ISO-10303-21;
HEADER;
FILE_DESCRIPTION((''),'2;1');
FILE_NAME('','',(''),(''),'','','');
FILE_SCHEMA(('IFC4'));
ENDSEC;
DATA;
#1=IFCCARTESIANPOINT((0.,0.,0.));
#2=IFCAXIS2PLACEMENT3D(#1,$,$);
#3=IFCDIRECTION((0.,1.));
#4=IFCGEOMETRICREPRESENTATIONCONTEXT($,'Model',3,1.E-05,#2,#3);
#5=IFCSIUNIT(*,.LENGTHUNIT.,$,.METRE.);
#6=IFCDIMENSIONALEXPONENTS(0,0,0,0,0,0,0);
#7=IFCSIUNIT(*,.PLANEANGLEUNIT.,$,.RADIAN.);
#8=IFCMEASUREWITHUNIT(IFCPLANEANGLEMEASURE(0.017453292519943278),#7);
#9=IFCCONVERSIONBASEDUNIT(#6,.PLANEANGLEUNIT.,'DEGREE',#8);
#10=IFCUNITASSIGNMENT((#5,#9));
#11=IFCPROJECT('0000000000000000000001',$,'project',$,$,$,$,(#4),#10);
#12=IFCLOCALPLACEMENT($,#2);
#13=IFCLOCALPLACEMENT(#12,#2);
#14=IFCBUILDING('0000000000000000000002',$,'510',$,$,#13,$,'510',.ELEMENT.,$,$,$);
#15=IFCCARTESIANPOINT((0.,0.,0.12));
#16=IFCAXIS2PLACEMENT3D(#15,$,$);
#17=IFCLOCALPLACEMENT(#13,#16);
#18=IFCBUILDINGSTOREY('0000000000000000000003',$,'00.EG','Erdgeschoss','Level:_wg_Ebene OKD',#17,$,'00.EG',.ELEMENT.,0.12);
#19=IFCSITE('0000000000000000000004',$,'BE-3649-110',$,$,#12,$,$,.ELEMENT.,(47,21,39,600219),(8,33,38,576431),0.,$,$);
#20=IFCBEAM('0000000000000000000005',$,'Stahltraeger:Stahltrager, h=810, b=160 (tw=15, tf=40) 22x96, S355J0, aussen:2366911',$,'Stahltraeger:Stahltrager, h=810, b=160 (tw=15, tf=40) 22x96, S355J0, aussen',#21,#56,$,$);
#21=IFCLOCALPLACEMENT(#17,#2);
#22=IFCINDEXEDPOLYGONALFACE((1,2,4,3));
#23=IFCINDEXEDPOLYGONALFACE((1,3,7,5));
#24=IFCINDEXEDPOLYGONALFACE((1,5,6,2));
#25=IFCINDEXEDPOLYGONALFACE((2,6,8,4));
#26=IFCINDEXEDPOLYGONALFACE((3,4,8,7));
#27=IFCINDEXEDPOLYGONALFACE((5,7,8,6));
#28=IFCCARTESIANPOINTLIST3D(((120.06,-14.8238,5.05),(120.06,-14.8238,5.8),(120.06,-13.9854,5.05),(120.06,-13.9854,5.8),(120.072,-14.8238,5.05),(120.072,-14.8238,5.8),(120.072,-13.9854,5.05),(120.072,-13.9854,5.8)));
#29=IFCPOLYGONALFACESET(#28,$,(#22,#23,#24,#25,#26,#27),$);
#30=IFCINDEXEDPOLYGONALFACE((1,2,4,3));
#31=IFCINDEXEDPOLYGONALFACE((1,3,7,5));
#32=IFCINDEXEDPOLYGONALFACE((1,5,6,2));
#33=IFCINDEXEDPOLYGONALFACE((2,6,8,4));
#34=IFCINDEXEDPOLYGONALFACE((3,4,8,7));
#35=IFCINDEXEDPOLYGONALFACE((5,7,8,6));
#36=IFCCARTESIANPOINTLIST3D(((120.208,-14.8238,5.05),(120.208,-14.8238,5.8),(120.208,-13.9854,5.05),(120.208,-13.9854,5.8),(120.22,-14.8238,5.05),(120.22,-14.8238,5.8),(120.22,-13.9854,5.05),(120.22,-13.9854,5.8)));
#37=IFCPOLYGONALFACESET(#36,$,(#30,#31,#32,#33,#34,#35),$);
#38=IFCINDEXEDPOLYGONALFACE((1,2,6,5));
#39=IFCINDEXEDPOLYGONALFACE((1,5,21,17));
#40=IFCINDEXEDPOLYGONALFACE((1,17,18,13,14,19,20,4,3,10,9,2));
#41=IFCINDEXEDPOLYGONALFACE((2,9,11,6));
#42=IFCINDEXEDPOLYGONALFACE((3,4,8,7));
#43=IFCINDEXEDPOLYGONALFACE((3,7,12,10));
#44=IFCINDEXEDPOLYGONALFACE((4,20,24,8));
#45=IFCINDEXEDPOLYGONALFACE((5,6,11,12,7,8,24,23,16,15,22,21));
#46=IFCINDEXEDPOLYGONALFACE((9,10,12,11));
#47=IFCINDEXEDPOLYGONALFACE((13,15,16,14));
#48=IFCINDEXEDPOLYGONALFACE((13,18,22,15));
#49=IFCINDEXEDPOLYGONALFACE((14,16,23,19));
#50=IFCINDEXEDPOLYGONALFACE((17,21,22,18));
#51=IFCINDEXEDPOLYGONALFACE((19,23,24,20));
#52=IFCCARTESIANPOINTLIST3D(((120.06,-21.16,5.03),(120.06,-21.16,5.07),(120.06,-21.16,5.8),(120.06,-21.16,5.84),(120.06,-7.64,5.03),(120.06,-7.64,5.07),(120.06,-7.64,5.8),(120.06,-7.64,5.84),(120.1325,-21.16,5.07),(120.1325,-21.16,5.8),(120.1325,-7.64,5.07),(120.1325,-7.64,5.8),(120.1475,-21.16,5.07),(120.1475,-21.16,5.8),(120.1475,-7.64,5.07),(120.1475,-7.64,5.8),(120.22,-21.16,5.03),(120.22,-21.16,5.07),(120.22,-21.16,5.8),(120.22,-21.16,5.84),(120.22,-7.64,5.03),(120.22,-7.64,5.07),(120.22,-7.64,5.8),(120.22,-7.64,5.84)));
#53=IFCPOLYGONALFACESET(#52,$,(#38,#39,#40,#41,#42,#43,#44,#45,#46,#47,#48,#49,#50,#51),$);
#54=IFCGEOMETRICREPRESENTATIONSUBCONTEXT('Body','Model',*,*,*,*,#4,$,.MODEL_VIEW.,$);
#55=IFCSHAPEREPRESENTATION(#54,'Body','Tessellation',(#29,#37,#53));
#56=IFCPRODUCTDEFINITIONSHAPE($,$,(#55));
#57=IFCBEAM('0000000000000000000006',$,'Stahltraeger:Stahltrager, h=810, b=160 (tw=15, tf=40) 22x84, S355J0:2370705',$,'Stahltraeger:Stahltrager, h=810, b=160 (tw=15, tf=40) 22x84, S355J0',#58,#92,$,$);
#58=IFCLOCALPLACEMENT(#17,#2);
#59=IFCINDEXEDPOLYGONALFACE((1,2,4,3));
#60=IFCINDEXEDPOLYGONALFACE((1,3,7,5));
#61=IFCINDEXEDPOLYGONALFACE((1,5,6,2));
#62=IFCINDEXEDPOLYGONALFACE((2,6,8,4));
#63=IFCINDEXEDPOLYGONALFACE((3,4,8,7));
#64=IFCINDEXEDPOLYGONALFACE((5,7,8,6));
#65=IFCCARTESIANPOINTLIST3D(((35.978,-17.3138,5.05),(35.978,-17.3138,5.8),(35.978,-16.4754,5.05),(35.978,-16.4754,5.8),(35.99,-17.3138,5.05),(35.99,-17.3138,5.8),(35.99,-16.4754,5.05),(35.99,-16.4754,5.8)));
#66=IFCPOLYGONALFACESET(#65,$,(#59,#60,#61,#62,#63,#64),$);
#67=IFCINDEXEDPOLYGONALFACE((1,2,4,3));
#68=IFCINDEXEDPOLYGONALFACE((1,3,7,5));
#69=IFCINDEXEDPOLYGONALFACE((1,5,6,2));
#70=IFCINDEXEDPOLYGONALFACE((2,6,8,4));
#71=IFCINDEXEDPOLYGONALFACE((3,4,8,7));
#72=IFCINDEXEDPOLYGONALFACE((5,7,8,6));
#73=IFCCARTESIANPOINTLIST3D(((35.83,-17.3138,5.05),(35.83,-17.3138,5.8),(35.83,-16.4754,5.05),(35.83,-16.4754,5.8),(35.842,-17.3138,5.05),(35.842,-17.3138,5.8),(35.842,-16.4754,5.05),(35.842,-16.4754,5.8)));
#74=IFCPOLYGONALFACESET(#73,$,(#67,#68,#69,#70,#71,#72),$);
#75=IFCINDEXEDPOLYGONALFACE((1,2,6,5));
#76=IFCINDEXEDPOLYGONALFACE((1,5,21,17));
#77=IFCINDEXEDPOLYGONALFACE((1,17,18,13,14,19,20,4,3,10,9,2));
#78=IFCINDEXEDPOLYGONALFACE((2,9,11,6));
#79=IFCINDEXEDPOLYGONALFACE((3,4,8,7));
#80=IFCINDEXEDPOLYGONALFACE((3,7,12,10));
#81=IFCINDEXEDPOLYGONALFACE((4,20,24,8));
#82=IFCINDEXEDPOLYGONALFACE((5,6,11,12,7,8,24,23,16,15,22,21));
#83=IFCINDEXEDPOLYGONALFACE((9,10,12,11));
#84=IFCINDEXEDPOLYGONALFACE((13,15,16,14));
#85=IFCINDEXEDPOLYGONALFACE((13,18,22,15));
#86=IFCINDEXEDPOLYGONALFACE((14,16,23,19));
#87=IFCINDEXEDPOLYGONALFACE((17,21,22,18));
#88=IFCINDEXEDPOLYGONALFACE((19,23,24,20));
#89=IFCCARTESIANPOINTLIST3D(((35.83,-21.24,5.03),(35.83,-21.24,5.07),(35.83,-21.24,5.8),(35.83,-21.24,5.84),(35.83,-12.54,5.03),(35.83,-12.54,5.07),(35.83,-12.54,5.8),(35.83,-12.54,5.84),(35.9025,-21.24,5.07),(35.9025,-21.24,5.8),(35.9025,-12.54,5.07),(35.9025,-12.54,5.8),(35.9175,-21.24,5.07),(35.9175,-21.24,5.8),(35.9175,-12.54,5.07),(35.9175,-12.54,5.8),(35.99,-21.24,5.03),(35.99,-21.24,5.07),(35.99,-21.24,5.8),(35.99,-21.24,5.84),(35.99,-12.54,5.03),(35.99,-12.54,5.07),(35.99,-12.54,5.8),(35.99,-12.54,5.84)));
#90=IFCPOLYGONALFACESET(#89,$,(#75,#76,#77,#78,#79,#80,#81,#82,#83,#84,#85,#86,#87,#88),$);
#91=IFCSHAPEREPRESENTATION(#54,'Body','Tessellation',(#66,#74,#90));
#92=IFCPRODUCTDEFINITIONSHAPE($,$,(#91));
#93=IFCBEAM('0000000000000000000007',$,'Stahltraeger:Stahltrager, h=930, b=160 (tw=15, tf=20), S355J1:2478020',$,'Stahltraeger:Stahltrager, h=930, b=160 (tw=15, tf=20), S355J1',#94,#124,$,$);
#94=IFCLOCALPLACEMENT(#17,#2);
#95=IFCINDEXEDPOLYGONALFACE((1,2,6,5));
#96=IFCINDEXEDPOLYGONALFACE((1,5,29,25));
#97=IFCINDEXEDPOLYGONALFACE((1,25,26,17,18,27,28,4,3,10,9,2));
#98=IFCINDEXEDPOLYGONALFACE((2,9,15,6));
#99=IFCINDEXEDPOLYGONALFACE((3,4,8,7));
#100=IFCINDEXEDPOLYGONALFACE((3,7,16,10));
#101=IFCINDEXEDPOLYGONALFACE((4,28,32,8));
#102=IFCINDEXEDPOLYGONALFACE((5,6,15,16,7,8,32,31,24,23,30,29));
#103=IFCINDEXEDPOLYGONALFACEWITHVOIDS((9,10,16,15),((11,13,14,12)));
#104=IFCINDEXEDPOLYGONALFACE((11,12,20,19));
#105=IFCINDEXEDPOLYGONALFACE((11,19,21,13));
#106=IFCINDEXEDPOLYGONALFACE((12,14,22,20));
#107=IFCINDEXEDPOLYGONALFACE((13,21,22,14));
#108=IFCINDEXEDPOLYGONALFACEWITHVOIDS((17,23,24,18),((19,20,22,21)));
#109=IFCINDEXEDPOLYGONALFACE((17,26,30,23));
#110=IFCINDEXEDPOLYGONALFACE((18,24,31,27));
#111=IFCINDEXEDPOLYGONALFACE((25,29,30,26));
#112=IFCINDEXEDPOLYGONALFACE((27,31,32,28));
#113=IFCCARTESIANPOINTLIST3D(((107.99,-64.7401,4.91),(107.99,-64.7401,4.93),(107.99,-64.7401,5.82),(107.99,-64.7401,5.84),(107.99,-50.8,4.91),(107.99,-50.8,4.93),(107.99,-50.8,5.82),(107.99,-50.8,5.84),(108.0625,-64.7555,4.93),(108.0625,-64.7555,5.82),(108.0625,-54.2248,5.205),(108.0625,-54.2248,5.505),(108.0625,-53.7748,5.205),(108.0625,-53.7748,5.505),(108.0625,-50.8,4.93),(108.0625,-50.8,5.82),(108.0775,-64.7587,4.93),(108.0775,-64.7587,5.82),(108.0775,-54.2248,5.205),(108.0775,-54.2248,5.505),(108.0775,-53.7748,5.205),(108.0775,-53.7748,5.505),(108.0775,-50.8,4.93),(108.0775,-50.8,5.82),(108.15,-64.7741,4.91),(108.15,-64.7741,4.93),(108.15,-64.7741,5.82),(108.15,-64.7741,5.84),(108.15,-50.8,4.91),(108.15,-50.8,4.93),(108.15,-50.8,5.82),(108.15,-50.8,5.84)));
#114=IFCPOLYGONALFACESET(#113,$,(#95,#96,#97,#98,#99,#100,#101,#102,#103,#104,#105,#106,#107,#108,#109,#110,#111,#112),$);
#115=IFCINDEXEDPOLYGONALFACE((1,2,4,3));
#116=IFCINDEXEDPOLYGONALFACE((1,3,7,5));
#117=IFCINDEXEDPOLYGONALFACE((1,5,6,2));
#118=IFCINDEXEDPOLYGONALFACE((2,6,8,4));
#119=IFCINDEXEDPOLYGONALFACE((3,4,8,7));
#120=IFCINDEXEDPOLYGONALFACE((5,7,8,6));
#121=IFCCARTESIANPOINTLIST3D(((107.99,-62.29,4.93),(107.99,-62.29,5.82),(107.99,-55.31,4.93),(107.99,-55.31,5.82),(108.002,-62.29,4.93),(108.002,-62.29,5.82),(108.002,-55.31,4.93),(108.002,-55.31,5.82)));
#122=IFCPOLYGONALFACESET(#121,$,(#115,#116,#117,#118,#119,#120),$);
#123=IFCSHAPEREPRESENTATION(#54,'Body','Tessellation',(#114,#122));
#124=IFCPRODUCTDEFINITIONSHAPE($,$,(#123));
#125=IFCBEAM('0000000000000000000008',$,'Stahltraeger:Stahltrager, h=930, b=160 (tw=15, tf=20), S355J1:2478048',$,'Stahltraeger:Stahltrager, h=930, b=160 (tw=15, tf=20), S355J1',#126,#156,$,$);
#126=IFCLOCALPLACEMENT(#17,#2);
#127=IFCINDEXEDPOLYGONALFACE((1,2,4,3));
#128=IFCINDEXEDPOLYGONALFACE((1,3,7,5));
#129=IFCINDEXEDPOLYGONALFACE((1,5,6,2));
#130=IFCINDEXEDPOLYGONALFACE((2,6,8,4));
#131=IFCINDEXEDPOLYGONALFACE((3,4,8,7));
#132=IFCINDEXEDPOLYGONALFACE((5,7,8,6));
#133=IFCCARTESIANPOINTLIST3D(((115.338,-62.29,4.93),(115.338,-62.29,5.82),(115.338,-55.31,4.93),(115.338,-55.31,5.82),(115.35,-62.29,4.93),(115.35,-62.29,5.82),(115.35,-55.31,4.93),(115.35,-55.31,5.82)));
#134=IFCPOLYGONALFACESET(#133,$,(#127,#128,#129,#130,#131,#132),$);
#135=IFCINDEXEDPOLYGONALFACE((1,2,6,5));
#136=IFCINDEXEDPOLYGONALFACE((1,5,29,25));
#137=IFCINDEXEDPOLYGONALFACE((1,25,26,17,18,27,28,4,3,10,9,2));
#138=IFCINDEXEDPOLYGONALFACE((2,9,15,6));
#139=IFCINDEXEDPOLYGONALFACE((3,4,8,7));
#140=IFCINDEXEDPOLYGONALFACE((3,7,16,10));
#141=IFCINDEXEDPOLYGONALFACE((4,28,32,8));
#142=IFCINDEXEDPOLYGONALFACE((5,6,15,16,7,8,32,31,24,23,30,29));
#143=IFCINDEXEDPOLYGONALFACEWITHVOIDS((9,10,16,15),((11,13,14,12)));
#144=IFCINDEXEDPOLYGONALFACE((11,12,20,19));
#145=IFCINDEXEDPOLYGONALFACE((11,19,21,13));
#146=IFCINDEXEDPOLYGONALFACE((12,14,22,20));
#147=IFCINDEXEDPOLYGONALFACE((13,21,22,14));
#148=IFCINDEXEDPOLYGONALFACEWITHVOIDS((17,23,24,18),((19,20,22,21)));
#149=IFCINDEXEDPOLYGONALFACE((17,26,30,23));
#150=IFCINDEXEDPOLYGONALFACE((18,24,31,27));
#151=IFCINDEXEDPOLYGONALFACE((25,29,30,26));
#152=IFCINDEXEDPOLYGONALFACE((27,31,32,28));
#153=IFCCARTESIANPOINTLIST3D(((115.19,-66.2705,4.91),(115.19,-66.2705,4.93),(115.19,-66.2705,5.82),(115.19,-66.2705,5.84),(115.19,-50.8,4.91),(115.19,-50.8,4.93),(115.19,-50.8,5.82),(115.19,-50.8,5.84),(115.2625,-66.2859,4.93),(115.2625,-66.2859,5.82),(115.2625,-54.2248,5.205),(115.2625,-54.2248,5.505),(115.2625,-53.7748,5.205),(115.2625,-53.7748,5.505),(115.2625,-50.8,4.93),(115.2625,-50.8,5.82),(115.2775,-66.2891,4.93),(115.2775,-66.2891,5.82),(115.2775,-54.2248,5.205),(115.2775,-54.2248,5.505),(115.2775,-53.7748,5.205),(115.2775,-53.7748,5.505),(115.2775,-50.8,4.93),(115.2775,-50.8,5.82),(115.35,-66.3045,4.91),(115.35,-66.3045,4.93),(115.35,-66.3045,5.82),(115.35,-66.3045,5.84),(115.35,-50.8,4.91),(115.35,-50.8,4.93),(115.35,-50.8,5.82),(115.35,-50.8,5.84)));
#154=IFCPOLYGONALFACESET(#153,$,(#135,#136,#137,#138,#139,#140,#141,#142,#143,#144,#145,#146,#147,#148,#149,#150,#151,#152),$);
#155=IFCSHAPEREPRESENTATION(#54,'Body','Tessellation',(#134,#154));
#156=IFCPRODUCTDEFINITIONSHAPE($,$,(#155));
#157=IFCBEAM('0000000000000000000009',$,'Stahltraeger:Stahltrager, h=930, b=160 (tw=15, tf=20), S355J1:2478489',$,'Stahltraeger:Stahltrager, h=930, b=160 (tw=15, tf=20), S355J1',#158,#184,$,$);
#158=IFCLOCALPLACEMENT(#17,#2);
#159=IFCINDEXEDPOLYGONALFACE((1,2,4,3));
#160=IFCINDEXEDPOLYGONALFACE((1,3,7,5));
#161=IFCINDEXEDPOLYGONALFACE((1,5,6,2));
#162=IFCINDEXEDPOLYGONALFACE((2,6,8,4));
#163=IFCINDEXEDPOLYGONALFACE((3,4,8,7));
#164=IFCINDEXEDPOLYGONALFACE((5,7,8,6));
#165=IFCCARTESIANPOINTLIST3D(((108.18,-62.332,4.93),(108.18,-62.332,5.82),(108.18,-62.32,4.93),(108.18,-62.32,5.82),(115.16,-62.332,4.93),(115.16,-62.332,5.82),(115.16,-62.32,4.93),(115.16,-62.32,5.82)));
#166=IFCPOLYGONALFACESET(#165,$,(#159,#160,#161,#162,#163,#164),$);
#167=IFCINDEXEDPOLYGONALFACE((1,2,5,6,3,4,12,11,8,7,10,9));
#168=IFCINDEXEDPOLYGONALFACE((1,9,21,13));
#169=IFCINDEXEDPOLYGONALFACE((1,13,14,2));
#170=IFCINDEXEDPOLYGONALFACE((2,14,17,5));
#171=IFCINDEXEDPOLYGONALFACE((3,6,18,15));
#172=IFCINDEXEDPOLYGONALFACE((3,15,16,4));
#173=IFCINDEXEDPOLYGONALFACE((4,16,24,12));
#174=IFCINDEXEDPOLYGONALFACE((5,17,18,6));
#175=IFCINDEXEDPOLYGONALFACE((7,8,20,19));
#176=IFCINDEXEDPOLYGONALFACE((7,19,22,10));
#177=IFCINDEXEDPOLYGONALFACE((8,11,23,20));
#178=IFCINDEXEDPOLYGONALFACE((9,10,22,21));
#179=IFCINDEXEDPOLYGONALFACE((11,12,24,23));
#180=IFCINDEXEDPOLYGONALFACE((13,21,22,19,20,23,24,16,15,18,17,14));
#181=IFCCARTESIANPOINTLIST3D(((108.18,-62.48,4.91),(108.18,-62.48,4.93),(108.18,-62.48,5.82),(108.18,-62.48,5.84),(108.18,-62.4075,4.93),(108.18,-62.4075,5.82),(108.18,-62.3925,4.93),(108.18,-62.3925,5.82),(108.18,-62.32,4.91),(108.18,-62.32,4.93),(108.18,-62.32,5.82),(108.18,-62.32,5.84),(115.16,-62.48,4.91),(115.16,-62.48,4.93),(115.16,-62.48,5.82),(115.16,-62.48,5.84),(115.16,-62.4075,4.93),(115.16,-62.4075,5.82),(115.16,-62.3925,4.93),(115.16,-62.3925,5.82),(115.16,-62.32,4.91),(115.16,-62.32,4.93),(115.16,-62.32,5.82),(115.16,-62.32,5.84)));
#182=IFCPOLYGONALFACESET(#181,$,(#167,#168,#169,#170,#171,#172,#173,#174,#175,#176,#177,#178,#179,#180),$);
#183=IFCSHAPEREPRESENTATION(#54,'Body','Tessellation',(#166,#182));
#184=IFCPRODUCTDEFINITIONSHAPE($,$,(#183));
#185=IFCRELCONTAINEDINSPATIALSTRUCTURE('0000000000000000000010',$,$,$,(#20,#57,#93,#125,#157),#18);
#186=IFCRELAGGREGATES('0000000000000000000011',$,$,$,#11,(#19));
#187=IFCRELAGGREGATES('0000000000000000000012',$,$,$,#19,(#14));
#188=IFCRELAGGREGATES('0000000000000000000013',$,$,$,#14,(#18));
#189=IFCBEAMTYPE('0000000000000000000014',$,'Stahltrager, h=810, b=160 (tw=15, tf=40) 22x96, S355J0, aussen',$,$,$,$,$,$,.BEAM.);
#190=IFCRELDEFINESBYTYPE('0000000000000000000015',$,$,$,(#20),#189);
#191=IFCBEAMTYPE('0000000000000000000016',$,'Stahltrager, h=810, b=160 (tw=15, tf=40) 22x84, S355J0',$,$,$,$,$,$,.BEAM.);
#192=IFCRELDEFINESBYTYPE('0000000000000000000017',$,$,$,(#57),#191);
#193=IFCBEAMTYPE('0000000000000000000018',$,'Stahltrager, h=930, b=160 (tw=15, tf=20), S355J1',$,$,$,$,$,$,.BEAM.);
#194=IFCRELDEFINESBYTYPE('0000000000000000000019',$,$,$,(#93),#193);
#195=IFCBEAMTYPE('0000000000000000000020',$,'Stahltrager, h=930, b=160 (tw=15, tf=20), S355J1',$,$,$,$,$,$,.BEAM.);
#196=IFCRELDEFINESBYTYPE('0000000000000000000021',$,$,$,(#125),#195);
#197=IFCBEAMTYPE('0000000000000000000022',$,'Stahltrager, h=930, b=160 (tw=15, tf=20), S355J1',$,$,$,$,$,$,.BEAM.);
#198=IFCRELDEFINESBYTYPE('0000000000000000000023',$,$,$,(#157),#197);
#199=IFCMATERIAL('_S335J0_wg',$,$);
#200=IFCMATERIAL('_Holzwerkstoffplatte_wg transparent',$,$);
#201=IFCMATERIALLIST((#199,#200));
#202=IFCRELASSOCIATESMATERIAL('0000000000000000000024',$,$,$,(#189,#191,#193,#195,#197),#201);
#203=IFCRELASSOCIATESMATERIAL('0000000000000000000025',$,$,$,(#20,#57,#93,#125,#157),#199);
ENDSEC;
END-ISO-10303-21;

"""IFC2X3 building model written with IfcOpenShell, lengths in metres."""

from ifc_helpers import new_model, entity, si_unit, converted_unit, direction, frame, frame_2d, origin, place, context, subcontext, project, spatial, rectangle, i_section, extrude, boolean, clip, halfspace, source, transform, mapped, material, material_list, type_object, type_shapes, element, save


model = new_model("IFC2X3")

# Units and contexts
model_context = context("Model", 3, precision=1e-05, world=origin(), true_north=direction((0.0, 1.0)))
body_context = subcontext(model_context, "Body", "Model", "MODEL_VIEW")
ifc_project = project(units=[si_unit("LENGTHUNIT", "METRE"), converted_unit("PLANEANGLEUNIT", "DEGREE", entity("IfcPlaneAngleMeasure", 0.017453292519943278), si_unit("PLANEANGLEUNIT", "RADIAN"), dimensions=[0, 0, 0, 0, 0, 0, 0])], contexts=[model_context])

# Site, building, storey
site_placement = place(None, origin())
site = spatial("IfcSite", under=ifc_project, at=site_placement, Name="BE-3649-110", CompositionType="ELEMENT", RefLatitude=(47, 21, 39, 600219), RefLongitude=(8, 33, 38, 576431), RefElevation=0.0)
building_placement = place(site_placement, origin())
building = spatial("IfcBuilding", under=site, at=building_placement, Name="510", LongName="510", CompositionType="ELEMENT")
storey_placement = place(building_placement, frame((0.0, 0.0, 0.12)))
storey = spatial("IfcBuildingStorey", under=building, at=storey_placement, Name="00.EG", Description="Erdgeschoss", ObjectType="Level:_wg_Ebene OKD", LongName="00.EG", CompositionType="ELEMENT", Elevation=0.12)

# Beams
ifc_material_1 = material(Name="_S335J0_wg")
ifc_material_2 = material(Name="_Holzwerkstoffplatte_wg transparent")
ifc_material_list = material_list([ifc_material_1, ifc_material_2])
beam_type_1 = type_object("IfcBeamType", Name="Stahltrager, h=810, b=160 (tw=15, tf=40) 22x96, S355J0, aussen", PredefinedType="BEAM", material=ifc_material_list)
shared_shape_1 = source(origin(), body_context, "Body", "SweptSolid", [
    extrude(rectangle(XDim=0.75, YDim=0.012, at=frame_2d((0.0, 0.0), x_axis=(0.0, 1.0))), frame((120.066, -13.9854, 5.545), z_axis=(0.0, -1.0, 0.0), x_axis=(-1.0, 0.0, 0.0)), (0.0, 0.0, 1.0), 0.8385),
    extrude(rectangle(XDim=0.75, YDim=0.012, at=frame_2d((0.0, 0.0), x_axis=(0.0, 1.0))), frame((120.214, -13.9854, 5.545), z_axis=(0.0, -1.0, 0.0), x_axis=(-1.0, 0.0, 0.0)), (0.0, 0.0, 1.0), 0.8385),
    extrude(i_section(OverallWidth=0.16, OverallDepth=0.81, WebThickness=0.015, FlangeThickness=0.04, at=frame_2d((0.0, 0.0), x_axis=(1.0, 0.0))), frame((120.14, -7.64, 5.555), z_axis=(0.0, -1.0, 0.0), x_axis=(-1.0, 0.0, 0.0)), (0.0, 0.0, 1.0), 13.52),
])
type_shapes(beam_type_1, [shared_shape_1])
beam_1_placement = place(storey_placement, frame((0.0, 0.0, -0.12)))
element("IfcBeam", 1, at=beam_1_placement, inside=storey, type_object=beam_type_1, material=ifc_material_1, Name="Stahltraeger:Stahltrager, h=810, b=160 (tw=15, tf=40) 22x96, S355J0, aussen:2366911", ObjectType="Stahltraeger:Stahltrager, h=810, b=160 (tw=15, tf=40) 22x96, S355J0, aussen", context=body_context, shape_type="MappedRepresentation", body=[
    mapped(shared_shape_1, transform((0.0, 0.0, 0.0), scale=1.0)),
])
beam_type_2 = type_object("IfcBeamType", Name="Stahltrager, h=810, b=160 (tw=15, tf=40) 22x84, S355J0", PredefinedType="BEAM", material=ifc_material_list)
shared_shape_2 = source(origin(), body_context, "Body", "SweptSolid", [
    extrude(rectangle(XDim=0.75, YDim=0.012, at=frame_2d((0.0, 0.0), x_axis=(0.0, 1.0))), frame((35.984, -16.4754, 5.545), z_axis=(0.0, -1.0, 0.0), x_axis=(-1.0, 0.0, 0.0)), (0.0, 0.0, 1.0), 0.8385),
    extrude(rectangle(XDim=0.75, YDim=0.012, at=frame_2d((0.0, 0.0), x_axis=(0.0, 1.0))), frame((35.836, -16.4754, 5.545), z_axis=(0.0, -1.0, 0.0), x_axis=(-1.0, 0.0, 0.0)), (0.0, 0.0, 1.0), 0.8385),
    extrude(i_section(OverallWidth=0.16, OverallDepth=0.81, WebThickness=0.015, FlangeThickness=0.04, at=frame_2d((0.0, 0.0), x_axis=(1.0, 0.0))), frame((35.91, -12.54, 5.555), z_axis=(0.0, -1.0, 0.0), x_axis=(-1.0, 0.0, 0.0)), (0.0, 0.0, 1.0), 8.7),
])
type_shapes(beam_type_2, [shared_shape_2])
beam_2_placement = place(storey_placement, frame((0.0, 0.0, -0.12)))
element("IfcBeam", 2, at=beam_2_placement, inside=storey, type_object=beam_type_2, material=ifc_material_1, Name="Stahltraeger:Stahltrager, h=810, b=160 (tw=15, tf=40) 22x84, S355J0:2370705", ObjectType="Stahltraeger:Stahltrager, h=810, b=160 (tw=15, tf=40) 22x84, S355J0", context=body_context, shape_type="MappedRepresentation", body=[
    mapped(shared_shape_2, transform((0.0, 0.0, 0.0), scale=1.0)),
])
beam_type_3 = type_object("IfcBeamType", Name="Stahltrager, h=930, b=160 (tw=15, tf=20), S355J1", PredefinedType="BEAM", material=ifc_material_list)
shared_shape_3 = source(origin(), body_context, "Body", "SweptSolid", [
    boolean("DIFFERENCE", clip(extrude(i_section(OverallWidth=0.16, OverallDepth=0.93, WebThickness=0.015, FlangeThickness=0.02, at=frame_2d((0.0, 0.0), x_axis=(1.0, 0.0))), frame((108.07, -50.8, 5.495), z_axis=(0.0, -1.0, 0.0), x_axis=(-1.0, 0.0, 0.0)), (0.0, 0.0, 1.0), 13.9741), halfspace(frame((108.3944, -64.826, -0.22), z_axis=(-0.207912, -0.978148, 0.0), x_axis=(-0.978148, 0.207912, 0.0)), False)), extrude(rectangle(XDim=0.3, YDim=0.45, at=frame_2d((0.0, 0.0), x_axis=(0.0, 1.0))), frame((108.0625, -53.9998, 5.475), z_axis=(1.0, 0.0, 0.0), x_axis=(0.0, -1.0, 0.0)), (0.0, 0.0, 1.0), 0.015)),
    extrude(rectangle(XDim=0.89, YDim=0.012, at=frame_2d((0.0, 0.0), x_axis=(0.0, 1.0))), frame((107.996, -55.31, 5.495), z_axis=(0.0, -1.0, 0.0), x_axis=(-1.0, 0.0, 0.0)), (0.0, 0.0, 1.0), 6.98),
])
type_shapes(beam_type_3, [shared_shape_3])
beam_3_placement = place(storey_placement, frame((0.0, 0.0, -0.12)))
element("IfcBeam", 3, at=beam_3_placement, inside=storey, type_object=beam_type_3, material=ifc_material_1, Name="Stahltraeger:Stahltrager, h=930, b=160 (tw=15, tf=20), S355J1:2478020", ObjectType="Stahltraeger:Stahltrager, h=930, b=160 (tw=15, tf=20), S355J1", context=body_context, shape_type="MappedRepresentation", body=[
    mapped(shared_shape_3, transform((0.0, 0.0, 0.0), scale=1.0)),
])
beam_type_4 = type_object("IfcBeamType", Name="Stahltrager, h=930, b=160 (tw=15, tf=20), S355J1", PredefinedType="BEAM", material=ifc_material_list)
shared_shape_4 = source(origin(), body_context, "Body", "SweptSolid", [
    extrude(rectangle(XDim=0.89, YDim=0.012, at=frame_2d((0.0, 0.0), x_axis=(0.0, 1.0))), frame((115.344, -55.31, 5.495), z_axis=(0.0, -1.0, 0.0), x_axis=(-1.0, 0.0, 0.0)), (0.0, 0.0, 1.0), 6.98),
    boolean("DIFFERENCE", clip(extrude(i_section(OverallWidth=0.16, OverallDepth=0.93, WebThickness=0.015, FlangeThickness=0.02, at=frame_2d((0.0, 0.0), x_axis=(1.0, 0.0))), frame((115.27, -50.8, 5.495), z_axis=(0.0, -1.0, 0.0), x_axis=(-1.0, 0.0, 0.0)), (0.0, 0.0, 1.0), 15.5045), halfspace(frame((115.7305, -66.3854, -0.22), z_axis=(-0.207912, -0.978148, 0.0), x_axis=(-0.978148, 0.207912, 0.0)), False)), extrude(rectangle(XDim=0.3, YDim=0.45, at=frame_2d((0.0, 0.0), x_axis=(0.0, 1.0))), frame((115.2625, -53.9998, 5.475), z_axis=(1.0, 0.0, 0.0), x_axis=(0.0, -1.0, 0.0)), (0.0, 0.0, 1.0), 0.015)),
])
type_shapes(beam_type_4, [shared_shape_4])
beam_4_placement = place(storey_placement, frame((0.0, 0.0, -0.12)))
element("IfcBeam", 4, at=beam_4_placement, inside=storey, type_object=beam_type_4, material=ifc_material_1, Name="Stahltraeger:Stahltrager, h=930, b=160 (tw=15, tf=20), S355J1:2478048", ObjectType="Stahltraeger:Stahltrager, h=930, b=160 (tw=15, tf=20), S355J1", context=body_context, shape_type="MappedRepresentation", body=[
    mapped(shared_shape_4, transform((0.0, 0.0, 0.0), scale=1.0)),
])
beam_type_5 = type_object("IfcBeamType", Name="Stahltrager, h=930, b=160 (tw=15, tf=20), S355J1", PredefinedType="BEAM", material=ifc_material_list)
shared_shape_5 = source(origin(), body_context, "Body", "SweptSolid", [
    extrude(rectangle(XDim=0.89, YDim=0.012, at=frame_2d((0.0, 0.0), x_axis=(1.0, 0.0))), frame((108.18, -62.326, 5.495), z_axis=(1.0, 0.0, 0.0), x_axis=(0.0, 0.0, -1.0)), (0.0, 0.0, 1.0), 6.98),
    extrude(i_section(OverallWidth=0.16, OverallDepth=0.93, WebThickness=0.015, FlangeThickness=0.02, at=frame_2d((0.0, 0.0), x_axis=(0.0, 1.0))), frame((108.18, -62.4, 5.495), z_axis=(1.0, 0.0, 0.0), x_axis=(0.0, 0.0, -1.0)), (0.0, 0.0, 1.0), 6.98),
])
type_shapes(beam_type_5, [shared_shape_5])
beam_5_placement = place(storey_placement, frame((0.0, 0.0, -0.12)))
element("IfcBeam", 5, at=beam_5_placement, inside=storey, type_object=beam_type_5, material=ifc_material_1, Name="Stahltraeger:Stahltrager, h=930, b=160 (tw=15, tf=20), S355J1:2478489", ObjectType="Stahltraeger:Stahltrager, h=930, b=160 (tw=15, tf=20), S355J1", context=body_context, shape_type="MappedRepresentation", body=[
    mapped(shared_shape_5, transform((0.0, 0.0, 0.0), scale=1.0)),
])

save(model, "model.ifc")
